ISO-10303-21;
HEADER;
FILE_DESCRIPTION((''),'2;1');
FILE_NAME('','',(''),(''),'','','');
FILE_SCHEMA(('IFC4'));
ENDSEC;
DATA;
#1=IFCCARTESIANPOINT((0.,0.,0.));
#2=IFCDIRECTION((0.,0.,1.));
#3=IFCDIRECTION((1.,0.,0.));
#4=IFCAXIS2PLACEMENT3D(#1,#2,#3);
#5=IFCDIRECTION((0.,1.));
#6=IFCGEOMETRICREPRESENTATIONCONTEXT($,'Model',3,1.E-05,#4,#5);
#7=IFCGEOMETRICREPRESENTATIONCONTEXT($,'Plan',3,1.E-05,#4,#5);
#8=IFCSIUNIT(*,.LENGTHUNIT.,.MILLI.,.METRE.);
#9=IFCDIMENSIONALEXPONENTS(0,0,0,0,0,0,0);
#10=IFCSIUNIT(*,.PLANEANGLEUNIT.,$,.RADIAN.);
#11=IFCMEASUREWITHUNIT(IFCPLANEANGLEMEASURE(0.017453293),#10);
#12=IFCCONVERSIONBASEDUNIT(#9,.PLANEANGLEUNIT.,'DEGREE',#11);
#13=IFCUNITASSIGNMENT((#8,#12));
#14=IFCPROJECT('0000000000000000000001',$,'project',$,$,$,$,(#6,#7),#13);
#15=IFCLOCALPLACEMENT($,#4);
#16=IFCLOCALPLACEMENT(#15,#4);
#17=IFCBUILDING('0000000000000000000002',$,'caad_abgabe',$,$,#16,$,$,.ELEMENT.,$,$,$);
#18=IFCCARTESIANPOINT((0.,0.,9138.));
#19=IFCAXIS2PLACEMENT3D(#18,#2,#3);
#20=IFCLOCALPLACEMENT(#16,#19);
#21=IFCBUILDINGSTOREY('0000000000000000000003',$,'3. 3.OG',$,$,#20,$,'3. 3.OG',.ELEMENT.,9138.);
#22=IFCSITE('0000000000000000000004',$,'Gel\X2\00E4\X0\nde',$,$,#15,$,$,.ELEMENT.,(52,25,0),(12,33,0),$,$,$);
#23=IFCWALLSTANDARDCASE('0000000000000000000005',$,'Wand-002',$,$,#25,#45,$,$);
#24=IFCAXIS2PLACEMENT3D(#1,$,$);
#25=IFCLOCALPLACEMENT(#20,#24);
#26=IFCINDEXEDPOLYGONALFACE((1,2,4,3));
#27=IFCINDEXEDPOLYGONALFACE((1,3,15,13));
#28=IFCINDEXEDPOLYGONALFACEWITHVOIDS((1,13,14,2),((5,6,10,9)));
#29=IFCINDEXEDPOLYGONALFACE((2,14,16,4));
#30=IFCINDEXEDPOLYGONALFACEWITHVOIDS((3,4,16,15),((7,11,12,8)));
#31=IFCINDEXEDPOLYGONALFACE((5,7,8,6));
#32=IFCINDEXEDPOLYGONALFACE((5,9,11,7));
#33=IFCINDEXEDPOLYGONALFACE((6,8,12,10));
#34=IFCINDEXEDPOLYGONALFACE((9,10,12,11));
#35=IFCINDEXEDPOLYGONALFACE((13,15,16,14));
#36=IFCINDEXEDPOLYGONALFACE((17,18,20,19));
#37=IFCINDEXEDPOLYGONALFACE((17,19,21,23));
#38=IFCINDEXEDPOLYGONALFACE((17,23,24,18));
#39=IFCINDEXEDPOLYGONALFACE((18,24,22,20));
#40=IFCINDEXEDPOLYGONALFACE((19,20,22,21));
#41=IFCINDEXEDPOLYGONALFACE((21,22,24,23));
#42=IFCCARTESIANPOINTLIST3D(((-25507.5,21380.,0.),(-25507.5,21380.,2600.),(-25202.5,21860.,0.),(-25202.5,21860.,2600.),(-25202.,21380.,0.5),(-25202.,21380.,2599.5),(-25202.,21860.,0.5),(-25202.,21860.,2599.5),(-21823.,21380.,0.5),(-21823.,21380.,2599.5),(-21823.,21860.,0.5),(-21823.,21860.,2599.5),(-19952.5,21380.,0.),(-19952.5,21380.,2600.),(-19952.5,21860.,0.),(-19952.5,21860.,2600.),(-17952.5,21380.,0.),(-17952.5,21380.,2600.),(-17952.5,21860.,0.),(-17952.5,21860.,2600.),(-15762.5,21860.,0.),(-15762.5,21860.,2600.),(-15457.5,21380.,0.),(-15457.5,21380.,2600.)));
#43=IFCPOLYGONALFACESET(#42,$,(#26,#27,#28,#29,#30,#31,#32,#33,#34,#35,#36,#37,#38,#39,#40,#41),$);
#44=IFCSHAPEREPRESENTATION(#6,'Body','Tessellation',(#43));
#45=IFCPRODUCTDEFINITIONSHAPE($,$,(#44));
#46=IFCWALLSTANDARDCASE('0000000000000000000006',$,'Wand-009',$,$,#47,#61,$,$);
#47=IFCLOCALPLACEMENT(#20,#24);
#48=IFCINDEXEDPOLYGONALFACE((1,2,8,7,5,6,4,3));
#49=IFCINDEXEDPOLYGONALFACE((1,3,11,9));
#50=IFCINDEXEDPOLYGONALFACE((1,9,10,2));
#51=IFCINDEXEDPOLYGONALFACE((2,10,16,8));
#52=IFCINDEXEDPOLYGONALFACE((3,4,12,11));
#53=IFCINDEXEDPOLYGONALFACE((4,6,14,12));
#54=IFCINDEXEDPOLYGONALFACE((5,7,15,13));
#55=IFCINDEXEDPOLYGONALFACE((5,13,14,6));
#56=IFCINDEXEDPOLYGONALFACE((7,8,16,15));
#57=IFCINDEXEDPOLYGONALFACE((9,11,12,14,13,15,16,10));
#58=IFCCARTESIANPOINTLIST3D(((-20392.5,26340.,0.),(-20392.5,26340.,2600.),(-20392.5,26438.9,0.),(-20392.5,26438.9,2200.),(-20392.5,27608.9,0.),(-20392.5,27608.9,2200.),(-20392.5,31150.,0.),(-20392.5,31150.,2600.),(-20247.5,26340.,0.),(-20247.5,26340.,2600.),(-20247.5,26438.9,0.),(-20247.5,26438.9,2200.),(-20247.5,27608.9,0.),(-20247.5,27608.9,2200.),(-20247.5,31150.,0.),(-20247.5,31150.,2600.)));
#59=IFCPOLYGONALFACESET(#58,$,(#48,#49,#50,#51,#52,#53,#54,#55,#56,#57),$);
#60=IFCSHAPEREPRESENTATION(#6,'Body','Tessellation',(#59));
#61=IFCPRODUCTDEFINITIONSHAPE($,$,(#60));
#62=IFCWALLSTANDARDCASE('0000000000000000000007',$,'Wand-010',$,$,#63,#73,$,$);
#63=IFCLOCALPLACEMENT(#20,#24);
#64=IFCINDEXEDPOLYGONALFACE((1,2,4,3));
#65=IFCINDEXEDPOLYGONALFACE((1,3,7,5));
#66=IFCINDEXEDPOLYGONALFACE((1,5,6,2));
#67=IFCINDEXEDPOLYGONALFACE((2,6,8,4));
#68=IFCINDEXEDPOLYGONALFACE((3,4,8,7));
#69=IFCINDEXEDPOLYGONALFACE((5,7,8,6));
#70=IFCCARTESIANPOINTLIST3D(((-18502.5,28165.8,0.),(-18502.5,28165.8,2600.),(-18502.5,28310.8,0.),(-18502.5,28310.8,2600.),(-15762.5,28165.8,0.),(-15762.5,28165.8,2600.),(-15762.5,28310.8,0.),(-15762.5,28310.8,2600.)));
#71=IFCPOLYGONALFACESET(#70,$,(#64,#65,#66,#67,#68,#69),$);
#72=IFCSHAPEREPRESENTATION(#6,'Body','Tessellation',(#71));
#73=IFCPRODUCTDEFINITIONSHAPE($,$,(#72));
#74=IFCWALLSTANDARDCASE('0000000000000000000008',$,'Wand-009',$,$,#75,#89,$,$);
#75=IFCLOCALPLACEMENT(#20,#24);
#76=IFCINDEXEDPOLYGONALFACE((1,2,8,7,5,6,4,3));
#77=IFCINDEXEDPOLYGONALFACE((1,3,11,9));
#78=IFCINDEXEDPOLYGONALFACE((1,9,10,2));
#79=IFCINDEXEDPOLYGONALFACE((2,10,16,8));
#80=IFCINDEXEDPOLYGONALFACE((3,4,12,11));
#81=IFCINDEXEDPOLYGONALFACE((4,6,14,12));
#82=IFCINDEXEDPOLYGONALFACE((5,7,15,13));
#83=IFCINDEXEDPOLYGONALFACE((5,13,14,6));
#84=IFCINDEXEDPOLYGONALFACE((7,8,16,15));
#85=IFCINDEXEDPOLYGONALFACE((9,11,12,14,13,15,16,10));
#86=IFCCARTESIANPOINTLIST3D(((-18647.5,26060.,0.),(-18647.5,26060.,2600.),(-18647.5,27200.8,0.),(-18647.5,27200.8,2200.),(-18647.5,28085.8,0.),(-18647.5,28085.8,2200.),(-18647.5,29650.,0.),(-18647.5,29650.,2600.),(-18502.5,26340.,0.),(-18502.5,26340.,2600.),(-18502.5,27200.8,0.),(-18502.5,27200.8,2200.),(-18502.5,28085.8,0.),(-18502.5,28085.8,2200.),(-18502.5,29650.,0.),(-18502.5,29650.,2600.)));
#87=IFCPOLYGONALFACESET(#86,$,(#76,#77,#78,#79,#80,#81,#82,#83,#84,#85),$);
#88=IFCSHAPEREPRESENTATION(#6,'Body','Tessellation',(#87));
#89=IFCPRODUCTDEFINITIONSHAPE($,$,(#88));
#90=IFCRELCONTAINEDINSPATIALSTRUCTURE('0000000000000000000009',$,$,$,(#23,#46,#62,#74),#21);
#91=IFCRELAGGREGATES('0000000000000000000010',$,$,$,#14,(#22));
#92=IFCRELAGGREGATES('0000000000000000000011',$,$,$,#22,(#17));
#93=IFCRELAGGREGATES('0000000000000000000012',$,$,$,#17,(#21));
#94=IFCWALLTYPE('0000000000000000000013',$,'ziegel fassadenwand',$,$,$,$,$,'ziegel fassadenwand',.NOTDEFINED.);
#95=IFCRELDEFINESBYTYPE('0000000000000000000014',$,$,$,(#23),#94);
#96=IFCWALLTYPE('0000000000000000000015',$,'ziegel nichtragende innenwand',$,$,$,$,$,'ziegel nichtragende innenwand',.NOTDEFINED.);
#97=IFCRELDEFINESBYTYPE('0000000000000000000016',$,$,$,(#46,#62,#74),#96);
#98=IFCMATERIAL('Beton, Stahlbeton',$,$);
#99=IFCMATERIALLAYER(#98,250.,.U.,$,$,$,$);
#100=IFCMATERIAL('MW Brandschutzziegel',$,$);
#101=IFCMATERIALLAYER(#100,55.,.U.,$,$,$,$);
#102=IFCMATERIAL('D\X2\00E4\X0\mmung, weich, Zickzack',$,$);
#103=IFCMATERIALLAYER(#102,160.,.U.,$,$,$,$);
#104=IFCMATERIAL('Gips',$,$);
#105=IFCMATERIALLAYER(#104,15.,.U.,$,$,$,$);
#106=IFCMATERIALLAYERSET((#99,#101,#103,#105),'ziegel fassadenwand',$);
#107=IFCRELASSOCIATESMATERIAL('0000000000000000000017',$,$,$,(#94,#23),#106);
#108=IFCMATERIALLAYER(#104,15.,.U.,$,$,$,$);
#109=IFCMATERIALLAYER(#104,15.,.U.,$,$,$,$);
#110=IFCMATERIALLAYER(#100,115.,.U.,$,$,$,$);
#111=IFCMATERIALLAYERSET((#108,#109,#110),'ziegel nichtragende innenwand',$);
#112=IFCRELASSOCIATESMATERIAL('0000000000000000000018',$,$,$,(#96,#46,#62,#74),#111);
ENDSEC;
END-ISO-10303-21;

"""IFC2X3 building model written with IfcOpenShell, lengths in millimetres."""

from ifc_helpers import new_model, entity, si_unit, converted_unit, direction, frame, frame_2d, origin_with_axes, place, context, project, spatial, polyline, rectangle, outline, extrude, material, layer, layer_set, layer_usage, type_object, element, save


model = new_model("IFC2X3")

# Units and contexts
model_context = context("Model", 3, precision=1e-05, world=origin_with_axes(), true_north=direction((0.0, 1.0)))
plan_context = context("Plan", 3, precision=1e-05, world=origin_with_axes(), true_north=direction((0.0, 1.0)))
ifc_project = project(units=[si_unit("LENGTHUNIT", "METRE", prefix="MILLI"), converted_unit("PLANEANGLEUNIT", "DEGREE", entity("IfcPlaneAngleMeasure", 0.017453293), si_unit("PLANEANGLEUNIT", "RADIAN"), dimensions=[0, 0, 0, 0, 0, 0, 0])], contexts=[model_context, plan_context])

# Site, building, storey
site_placement = place(None, origin_with_axes())
site = spatial("IfcSite", under=ifc_project, at=site_placement, Name="Gelände", CompositionType="ELEMENT", RefLatitude=(52, 25, 0), RefLongitude=(12, 33, 0))
building_placement = place(site_placement, origin_with_axes())
building = spatial("IfcBuilding", under=site, at=building_placement, Name="caad_abgabe", CompositionType="ELEMENT")
storey_placement = place(building_placement, frame((0.0, 0.0, 9138.0), z_axis=(0.0, 0.0, 1.0), x_axis=(1.0, 0.0, 0.0)))
storey = spatial("IfcBuildingStorey", under=building, at=storey_placement, Name="3. 3.OG", LongName="3. 3.OG", CompositionType="ELEMENT", Elevation=9138.0)

# Shared definitions
ifc_material_1 = material(Name="Gips")
ifc_material_2 = material(Name="Beton, Stahlbeton")

# Wall, openings
ifc_layer_1 = layer(ifc_material_2, 250.0, ventilated="UNKNOWN")
ifc_material_3 = material(Name="MW Brandschutzziegel")
ifc_layer_2 = layer(ifc_material_3, 55.0, ventilated="UNKNOWN")
ifc_material_4 = material(Name="Dämmung, weich, Zickzack")
ifc_layer_3 = layer(ifc_material_4, 160.0, ventilated="UNKNOWN")
ifc_layer_4 = layer(ifc_material_1, 15.0, ventilated="UNKNOWN")
ifc_layer_set_1 = layer_set([ifc_layer_1, ifc_layer_2, ifc_layer_3, ifc_layer_4], Name="ziegel fassadenwand")
ifc_layer_usage_1 = layer_usage(ifc_layer_set_1, "AXIS2", "POSITIVE", 0.0)
wall_type_1 = type_object("IfcWallType", Name="ziegel fassadenwand", ElementType="ziegel fassadenwand", PredefinedType="NOTDEFINED", material=ifc_layer_set_1)
wall_1_placement = place(storey_placement, frame((-25507.5, 21380.0, 0.0), z_axis=(0.0, 0.0, 1.0), x_axis=(1.0, 0.0, 0.0)))
wall_1 = element("IfcWallStandardCase", 1, at=wall_1_placement, inside=storey, type_object=wall_type_1, material=ifc_layer_usage_1, Name="Wand-002", context=model_context, shape_type="SweptSolid", body=[
    extrude(outline(polyline([(0.0, 0.0), (10050.0, 0.0), (9745.0, 480.0), (305.0, 480.0), (0.0, 0.0)])), origin_with_axes(), (0.0, 0.0, 1.0), 2600.0),
])
opening_1_placement = place(wall_1_placement, frame((1995.0, 0.0, 0.0), z_axis=(0.0, 0.0, 1.0), x_axis=(1.0, 0.0, 0.0)))
element("IfcOpeningElement", 2, at=opening_1_placement, cuts=wall_1, ObjectType="Opening", context=model_context, shape_type="SweptSolid", body=[
    extrude(rectangle(XDim=3379.0, YDim=2599.0, at=frame_2d((0.0, 1300.0), x_axis=(1.0, 0.0))), frame((0.0, 0.0, 0.0), z_axis=(0.0, 1.0, 0.0), x_axis=(-1.0, 0.0, 0.0)), (0.0, 0.0, 1.0), 480.0),
])
opening_2_placement = place(wall_1_placement, frame((6555.0, 0.0, 0.0), z_axis=(0.0, 0.0, 1.0), x_axis=(1.0, 0.0, 0.0)))
element("IfcOpeningElement", 3, at=opening_2_placement, cuts=wall_1, ObjectType="Opening", context=model_context, shape_type="SweptSolid", body=[
    extrude(rectangle(XDim=2000.0, YDim=2600.0, at=frame_2d((0.0, 1300.0), x_axis=(1.0, 0.0))), frame((0.0, 0.0, 0.0), z_axis=(0.0, 1.0, 0.0), x_axis=(-1.0, 0.0, 0.0)), (0.0, 0.0, 1.0), 480.0),
])

# Wall, opening
ifc_layer_5 = layer(ifc_material_1, 15.0, ventilated="UNKNOWN")
ifc_layer_6 = layer(ifc_material_1, 15.0, ventilated="UNKNOWN")
ifc_layer_7 = layer(ifc_material_3, 115.0, ventilated="UNKNOWN")
ifc_layer_set_2 = layer_set([ifc_layer_5, ifc_layer_6, ifc_layer_7], Name="ziegel nichtragende innenwand")
ifc_layer_usage_2 = layer_usage(ifc_layer_set_2, "AXIS2", "POSITIVE", 0.0)
wall_type_2 = type_object("IfcWallType", Name="ziegel nichtragende innenwand", ElementType="ziegel nichtragende innenwand", PredefinedType="NOTDEFINED", material=ifc_layer_set_2)
wall_2_placement = place(storey_placement, frame((-20392.5, 31150.0, 0.0), z_axis=(0.0, 0.0, 1.0), x_axis=(0.0, -1.0, 0.0)))
wall_2 = element("IfcWallStandardCase", 4, at=wall_2_placement, inside=storey, type_object=wall_type_2, material=ifc_layer_usage_2, Name="Wand-009", context=model_context, shape_type="SweptSolid", body=[
    extrude(outline(polyline([(0.0, 0.0), (4810.0, 0.0), (4810.0, 145.0), (0.0, 145.0), (0.0, 0.0)])), origin_with_axes(), (0.0, 0.0, 1.0), 2600.0),
])
opening_3_placement = place(wall_2_placement, frame((4126.2, 0.0, 0.0), z_axis=(0.0, 0.0, 1.0), x_axis=(1.0, 0.0, 0.0)))
element("IfcOpeningElement", 5, at=opening_3_placement, cuts=wall_2, ObjectType="Opening", context=model_context, shape_type="SweptSolid", body=[
    extrude(rectangle(XDim=1170.0, YDim=2200.0, at=frame_2d((0.0, 1100.0), x_axis=(-1.0, 0.0))), frame((0.0, 0.0, 0.0), z_axis=(0.0, 1.0, 0.0), x_axis=(-1.0, 0.0, 0.0)), (0.0, 0.0, 1.0), 145.0),
])

# Wall
ifc_layer_usage_3 = layer_usage(ifc_layer_set_2, "AXIS2", "NEGATIVE", 72.5)
wall_3_placement = place(storey_placement, frame((-18647.5, 28238.3, 0.0), z_axis=(0.0, 0.0, 1.0), x_axis=(1.0, 0.0, 0.0)))
element("IfcWallStandardCase", 6, at=wall_3_placement, inside=storey, type_object=wall_type_2, material=ifc_layer_usage_3, Name="Wand-010", context=model_context, shape_type="SweptSolid", body=[
    extrude(outline(polyline([(145.0, -72.5), (2885.0, -72.5), (2885.0, 72.5), (145.0, 72.5), (145.0, -72.5)])), origin_with_axes(), (0.0, 0.0, 1.0), 2600.0),
])

# Wall, opening
ifc_layer_usage_4 = layer_usage(ifc_layer_set_2, "AXIS2", "NEGATIVE", 0.0)
wall_4_placement = place(storey_placement, frame((-18647.5, 26340.0, 0.0), z_axis=(0.0, 0.0, 1.0), x_axis=(0.0, 1.0, 0.0)))
wall_4 = element("IfcWallStandardCase", 7, at=wall_4_placement, inside=storey, type_object=wall_type_2, material=ifc_layer_usage_4, Name="Wand-009", context=model_context, shape_type="SweptSolid", body=[
    extrude(outline(polyline([(0.0, -145.0), (3310.0, -145.0), (3310.0, 0.0), (-280.0, 0.0), (0.0, -145.0)])), origin_with_axes(), (0.0, 0.0, 1.0), 2600.0),
])
opening_4_placement = place(wall_4_placement, frame((1303.2, -145.0, 0.0), z_axis=(0.0, 0.0, 1.0), x_axis=(1.0, 0.0, 0.0)))
element("IfcOpeningElement", 8, at=opening_4_placement, cuts=wall_4, ObjectType="Opening", context=model_context, shape_type="SweptSolid", body=[
    extrude(rectangle(XDim=885.0, YDim=2200.0, at=frame_2d((0.0, 1100.0), x_axis=(-1.0, 0.0))), frame((0.0, 0.0, 0.0), z_axis=(0.0, 1.0, 0.0), x_axis=(-1.0, 0.0, 0.0)), (0.0, 0.0, 1.0), 145.0),
])

save(model, "model.ifc")
